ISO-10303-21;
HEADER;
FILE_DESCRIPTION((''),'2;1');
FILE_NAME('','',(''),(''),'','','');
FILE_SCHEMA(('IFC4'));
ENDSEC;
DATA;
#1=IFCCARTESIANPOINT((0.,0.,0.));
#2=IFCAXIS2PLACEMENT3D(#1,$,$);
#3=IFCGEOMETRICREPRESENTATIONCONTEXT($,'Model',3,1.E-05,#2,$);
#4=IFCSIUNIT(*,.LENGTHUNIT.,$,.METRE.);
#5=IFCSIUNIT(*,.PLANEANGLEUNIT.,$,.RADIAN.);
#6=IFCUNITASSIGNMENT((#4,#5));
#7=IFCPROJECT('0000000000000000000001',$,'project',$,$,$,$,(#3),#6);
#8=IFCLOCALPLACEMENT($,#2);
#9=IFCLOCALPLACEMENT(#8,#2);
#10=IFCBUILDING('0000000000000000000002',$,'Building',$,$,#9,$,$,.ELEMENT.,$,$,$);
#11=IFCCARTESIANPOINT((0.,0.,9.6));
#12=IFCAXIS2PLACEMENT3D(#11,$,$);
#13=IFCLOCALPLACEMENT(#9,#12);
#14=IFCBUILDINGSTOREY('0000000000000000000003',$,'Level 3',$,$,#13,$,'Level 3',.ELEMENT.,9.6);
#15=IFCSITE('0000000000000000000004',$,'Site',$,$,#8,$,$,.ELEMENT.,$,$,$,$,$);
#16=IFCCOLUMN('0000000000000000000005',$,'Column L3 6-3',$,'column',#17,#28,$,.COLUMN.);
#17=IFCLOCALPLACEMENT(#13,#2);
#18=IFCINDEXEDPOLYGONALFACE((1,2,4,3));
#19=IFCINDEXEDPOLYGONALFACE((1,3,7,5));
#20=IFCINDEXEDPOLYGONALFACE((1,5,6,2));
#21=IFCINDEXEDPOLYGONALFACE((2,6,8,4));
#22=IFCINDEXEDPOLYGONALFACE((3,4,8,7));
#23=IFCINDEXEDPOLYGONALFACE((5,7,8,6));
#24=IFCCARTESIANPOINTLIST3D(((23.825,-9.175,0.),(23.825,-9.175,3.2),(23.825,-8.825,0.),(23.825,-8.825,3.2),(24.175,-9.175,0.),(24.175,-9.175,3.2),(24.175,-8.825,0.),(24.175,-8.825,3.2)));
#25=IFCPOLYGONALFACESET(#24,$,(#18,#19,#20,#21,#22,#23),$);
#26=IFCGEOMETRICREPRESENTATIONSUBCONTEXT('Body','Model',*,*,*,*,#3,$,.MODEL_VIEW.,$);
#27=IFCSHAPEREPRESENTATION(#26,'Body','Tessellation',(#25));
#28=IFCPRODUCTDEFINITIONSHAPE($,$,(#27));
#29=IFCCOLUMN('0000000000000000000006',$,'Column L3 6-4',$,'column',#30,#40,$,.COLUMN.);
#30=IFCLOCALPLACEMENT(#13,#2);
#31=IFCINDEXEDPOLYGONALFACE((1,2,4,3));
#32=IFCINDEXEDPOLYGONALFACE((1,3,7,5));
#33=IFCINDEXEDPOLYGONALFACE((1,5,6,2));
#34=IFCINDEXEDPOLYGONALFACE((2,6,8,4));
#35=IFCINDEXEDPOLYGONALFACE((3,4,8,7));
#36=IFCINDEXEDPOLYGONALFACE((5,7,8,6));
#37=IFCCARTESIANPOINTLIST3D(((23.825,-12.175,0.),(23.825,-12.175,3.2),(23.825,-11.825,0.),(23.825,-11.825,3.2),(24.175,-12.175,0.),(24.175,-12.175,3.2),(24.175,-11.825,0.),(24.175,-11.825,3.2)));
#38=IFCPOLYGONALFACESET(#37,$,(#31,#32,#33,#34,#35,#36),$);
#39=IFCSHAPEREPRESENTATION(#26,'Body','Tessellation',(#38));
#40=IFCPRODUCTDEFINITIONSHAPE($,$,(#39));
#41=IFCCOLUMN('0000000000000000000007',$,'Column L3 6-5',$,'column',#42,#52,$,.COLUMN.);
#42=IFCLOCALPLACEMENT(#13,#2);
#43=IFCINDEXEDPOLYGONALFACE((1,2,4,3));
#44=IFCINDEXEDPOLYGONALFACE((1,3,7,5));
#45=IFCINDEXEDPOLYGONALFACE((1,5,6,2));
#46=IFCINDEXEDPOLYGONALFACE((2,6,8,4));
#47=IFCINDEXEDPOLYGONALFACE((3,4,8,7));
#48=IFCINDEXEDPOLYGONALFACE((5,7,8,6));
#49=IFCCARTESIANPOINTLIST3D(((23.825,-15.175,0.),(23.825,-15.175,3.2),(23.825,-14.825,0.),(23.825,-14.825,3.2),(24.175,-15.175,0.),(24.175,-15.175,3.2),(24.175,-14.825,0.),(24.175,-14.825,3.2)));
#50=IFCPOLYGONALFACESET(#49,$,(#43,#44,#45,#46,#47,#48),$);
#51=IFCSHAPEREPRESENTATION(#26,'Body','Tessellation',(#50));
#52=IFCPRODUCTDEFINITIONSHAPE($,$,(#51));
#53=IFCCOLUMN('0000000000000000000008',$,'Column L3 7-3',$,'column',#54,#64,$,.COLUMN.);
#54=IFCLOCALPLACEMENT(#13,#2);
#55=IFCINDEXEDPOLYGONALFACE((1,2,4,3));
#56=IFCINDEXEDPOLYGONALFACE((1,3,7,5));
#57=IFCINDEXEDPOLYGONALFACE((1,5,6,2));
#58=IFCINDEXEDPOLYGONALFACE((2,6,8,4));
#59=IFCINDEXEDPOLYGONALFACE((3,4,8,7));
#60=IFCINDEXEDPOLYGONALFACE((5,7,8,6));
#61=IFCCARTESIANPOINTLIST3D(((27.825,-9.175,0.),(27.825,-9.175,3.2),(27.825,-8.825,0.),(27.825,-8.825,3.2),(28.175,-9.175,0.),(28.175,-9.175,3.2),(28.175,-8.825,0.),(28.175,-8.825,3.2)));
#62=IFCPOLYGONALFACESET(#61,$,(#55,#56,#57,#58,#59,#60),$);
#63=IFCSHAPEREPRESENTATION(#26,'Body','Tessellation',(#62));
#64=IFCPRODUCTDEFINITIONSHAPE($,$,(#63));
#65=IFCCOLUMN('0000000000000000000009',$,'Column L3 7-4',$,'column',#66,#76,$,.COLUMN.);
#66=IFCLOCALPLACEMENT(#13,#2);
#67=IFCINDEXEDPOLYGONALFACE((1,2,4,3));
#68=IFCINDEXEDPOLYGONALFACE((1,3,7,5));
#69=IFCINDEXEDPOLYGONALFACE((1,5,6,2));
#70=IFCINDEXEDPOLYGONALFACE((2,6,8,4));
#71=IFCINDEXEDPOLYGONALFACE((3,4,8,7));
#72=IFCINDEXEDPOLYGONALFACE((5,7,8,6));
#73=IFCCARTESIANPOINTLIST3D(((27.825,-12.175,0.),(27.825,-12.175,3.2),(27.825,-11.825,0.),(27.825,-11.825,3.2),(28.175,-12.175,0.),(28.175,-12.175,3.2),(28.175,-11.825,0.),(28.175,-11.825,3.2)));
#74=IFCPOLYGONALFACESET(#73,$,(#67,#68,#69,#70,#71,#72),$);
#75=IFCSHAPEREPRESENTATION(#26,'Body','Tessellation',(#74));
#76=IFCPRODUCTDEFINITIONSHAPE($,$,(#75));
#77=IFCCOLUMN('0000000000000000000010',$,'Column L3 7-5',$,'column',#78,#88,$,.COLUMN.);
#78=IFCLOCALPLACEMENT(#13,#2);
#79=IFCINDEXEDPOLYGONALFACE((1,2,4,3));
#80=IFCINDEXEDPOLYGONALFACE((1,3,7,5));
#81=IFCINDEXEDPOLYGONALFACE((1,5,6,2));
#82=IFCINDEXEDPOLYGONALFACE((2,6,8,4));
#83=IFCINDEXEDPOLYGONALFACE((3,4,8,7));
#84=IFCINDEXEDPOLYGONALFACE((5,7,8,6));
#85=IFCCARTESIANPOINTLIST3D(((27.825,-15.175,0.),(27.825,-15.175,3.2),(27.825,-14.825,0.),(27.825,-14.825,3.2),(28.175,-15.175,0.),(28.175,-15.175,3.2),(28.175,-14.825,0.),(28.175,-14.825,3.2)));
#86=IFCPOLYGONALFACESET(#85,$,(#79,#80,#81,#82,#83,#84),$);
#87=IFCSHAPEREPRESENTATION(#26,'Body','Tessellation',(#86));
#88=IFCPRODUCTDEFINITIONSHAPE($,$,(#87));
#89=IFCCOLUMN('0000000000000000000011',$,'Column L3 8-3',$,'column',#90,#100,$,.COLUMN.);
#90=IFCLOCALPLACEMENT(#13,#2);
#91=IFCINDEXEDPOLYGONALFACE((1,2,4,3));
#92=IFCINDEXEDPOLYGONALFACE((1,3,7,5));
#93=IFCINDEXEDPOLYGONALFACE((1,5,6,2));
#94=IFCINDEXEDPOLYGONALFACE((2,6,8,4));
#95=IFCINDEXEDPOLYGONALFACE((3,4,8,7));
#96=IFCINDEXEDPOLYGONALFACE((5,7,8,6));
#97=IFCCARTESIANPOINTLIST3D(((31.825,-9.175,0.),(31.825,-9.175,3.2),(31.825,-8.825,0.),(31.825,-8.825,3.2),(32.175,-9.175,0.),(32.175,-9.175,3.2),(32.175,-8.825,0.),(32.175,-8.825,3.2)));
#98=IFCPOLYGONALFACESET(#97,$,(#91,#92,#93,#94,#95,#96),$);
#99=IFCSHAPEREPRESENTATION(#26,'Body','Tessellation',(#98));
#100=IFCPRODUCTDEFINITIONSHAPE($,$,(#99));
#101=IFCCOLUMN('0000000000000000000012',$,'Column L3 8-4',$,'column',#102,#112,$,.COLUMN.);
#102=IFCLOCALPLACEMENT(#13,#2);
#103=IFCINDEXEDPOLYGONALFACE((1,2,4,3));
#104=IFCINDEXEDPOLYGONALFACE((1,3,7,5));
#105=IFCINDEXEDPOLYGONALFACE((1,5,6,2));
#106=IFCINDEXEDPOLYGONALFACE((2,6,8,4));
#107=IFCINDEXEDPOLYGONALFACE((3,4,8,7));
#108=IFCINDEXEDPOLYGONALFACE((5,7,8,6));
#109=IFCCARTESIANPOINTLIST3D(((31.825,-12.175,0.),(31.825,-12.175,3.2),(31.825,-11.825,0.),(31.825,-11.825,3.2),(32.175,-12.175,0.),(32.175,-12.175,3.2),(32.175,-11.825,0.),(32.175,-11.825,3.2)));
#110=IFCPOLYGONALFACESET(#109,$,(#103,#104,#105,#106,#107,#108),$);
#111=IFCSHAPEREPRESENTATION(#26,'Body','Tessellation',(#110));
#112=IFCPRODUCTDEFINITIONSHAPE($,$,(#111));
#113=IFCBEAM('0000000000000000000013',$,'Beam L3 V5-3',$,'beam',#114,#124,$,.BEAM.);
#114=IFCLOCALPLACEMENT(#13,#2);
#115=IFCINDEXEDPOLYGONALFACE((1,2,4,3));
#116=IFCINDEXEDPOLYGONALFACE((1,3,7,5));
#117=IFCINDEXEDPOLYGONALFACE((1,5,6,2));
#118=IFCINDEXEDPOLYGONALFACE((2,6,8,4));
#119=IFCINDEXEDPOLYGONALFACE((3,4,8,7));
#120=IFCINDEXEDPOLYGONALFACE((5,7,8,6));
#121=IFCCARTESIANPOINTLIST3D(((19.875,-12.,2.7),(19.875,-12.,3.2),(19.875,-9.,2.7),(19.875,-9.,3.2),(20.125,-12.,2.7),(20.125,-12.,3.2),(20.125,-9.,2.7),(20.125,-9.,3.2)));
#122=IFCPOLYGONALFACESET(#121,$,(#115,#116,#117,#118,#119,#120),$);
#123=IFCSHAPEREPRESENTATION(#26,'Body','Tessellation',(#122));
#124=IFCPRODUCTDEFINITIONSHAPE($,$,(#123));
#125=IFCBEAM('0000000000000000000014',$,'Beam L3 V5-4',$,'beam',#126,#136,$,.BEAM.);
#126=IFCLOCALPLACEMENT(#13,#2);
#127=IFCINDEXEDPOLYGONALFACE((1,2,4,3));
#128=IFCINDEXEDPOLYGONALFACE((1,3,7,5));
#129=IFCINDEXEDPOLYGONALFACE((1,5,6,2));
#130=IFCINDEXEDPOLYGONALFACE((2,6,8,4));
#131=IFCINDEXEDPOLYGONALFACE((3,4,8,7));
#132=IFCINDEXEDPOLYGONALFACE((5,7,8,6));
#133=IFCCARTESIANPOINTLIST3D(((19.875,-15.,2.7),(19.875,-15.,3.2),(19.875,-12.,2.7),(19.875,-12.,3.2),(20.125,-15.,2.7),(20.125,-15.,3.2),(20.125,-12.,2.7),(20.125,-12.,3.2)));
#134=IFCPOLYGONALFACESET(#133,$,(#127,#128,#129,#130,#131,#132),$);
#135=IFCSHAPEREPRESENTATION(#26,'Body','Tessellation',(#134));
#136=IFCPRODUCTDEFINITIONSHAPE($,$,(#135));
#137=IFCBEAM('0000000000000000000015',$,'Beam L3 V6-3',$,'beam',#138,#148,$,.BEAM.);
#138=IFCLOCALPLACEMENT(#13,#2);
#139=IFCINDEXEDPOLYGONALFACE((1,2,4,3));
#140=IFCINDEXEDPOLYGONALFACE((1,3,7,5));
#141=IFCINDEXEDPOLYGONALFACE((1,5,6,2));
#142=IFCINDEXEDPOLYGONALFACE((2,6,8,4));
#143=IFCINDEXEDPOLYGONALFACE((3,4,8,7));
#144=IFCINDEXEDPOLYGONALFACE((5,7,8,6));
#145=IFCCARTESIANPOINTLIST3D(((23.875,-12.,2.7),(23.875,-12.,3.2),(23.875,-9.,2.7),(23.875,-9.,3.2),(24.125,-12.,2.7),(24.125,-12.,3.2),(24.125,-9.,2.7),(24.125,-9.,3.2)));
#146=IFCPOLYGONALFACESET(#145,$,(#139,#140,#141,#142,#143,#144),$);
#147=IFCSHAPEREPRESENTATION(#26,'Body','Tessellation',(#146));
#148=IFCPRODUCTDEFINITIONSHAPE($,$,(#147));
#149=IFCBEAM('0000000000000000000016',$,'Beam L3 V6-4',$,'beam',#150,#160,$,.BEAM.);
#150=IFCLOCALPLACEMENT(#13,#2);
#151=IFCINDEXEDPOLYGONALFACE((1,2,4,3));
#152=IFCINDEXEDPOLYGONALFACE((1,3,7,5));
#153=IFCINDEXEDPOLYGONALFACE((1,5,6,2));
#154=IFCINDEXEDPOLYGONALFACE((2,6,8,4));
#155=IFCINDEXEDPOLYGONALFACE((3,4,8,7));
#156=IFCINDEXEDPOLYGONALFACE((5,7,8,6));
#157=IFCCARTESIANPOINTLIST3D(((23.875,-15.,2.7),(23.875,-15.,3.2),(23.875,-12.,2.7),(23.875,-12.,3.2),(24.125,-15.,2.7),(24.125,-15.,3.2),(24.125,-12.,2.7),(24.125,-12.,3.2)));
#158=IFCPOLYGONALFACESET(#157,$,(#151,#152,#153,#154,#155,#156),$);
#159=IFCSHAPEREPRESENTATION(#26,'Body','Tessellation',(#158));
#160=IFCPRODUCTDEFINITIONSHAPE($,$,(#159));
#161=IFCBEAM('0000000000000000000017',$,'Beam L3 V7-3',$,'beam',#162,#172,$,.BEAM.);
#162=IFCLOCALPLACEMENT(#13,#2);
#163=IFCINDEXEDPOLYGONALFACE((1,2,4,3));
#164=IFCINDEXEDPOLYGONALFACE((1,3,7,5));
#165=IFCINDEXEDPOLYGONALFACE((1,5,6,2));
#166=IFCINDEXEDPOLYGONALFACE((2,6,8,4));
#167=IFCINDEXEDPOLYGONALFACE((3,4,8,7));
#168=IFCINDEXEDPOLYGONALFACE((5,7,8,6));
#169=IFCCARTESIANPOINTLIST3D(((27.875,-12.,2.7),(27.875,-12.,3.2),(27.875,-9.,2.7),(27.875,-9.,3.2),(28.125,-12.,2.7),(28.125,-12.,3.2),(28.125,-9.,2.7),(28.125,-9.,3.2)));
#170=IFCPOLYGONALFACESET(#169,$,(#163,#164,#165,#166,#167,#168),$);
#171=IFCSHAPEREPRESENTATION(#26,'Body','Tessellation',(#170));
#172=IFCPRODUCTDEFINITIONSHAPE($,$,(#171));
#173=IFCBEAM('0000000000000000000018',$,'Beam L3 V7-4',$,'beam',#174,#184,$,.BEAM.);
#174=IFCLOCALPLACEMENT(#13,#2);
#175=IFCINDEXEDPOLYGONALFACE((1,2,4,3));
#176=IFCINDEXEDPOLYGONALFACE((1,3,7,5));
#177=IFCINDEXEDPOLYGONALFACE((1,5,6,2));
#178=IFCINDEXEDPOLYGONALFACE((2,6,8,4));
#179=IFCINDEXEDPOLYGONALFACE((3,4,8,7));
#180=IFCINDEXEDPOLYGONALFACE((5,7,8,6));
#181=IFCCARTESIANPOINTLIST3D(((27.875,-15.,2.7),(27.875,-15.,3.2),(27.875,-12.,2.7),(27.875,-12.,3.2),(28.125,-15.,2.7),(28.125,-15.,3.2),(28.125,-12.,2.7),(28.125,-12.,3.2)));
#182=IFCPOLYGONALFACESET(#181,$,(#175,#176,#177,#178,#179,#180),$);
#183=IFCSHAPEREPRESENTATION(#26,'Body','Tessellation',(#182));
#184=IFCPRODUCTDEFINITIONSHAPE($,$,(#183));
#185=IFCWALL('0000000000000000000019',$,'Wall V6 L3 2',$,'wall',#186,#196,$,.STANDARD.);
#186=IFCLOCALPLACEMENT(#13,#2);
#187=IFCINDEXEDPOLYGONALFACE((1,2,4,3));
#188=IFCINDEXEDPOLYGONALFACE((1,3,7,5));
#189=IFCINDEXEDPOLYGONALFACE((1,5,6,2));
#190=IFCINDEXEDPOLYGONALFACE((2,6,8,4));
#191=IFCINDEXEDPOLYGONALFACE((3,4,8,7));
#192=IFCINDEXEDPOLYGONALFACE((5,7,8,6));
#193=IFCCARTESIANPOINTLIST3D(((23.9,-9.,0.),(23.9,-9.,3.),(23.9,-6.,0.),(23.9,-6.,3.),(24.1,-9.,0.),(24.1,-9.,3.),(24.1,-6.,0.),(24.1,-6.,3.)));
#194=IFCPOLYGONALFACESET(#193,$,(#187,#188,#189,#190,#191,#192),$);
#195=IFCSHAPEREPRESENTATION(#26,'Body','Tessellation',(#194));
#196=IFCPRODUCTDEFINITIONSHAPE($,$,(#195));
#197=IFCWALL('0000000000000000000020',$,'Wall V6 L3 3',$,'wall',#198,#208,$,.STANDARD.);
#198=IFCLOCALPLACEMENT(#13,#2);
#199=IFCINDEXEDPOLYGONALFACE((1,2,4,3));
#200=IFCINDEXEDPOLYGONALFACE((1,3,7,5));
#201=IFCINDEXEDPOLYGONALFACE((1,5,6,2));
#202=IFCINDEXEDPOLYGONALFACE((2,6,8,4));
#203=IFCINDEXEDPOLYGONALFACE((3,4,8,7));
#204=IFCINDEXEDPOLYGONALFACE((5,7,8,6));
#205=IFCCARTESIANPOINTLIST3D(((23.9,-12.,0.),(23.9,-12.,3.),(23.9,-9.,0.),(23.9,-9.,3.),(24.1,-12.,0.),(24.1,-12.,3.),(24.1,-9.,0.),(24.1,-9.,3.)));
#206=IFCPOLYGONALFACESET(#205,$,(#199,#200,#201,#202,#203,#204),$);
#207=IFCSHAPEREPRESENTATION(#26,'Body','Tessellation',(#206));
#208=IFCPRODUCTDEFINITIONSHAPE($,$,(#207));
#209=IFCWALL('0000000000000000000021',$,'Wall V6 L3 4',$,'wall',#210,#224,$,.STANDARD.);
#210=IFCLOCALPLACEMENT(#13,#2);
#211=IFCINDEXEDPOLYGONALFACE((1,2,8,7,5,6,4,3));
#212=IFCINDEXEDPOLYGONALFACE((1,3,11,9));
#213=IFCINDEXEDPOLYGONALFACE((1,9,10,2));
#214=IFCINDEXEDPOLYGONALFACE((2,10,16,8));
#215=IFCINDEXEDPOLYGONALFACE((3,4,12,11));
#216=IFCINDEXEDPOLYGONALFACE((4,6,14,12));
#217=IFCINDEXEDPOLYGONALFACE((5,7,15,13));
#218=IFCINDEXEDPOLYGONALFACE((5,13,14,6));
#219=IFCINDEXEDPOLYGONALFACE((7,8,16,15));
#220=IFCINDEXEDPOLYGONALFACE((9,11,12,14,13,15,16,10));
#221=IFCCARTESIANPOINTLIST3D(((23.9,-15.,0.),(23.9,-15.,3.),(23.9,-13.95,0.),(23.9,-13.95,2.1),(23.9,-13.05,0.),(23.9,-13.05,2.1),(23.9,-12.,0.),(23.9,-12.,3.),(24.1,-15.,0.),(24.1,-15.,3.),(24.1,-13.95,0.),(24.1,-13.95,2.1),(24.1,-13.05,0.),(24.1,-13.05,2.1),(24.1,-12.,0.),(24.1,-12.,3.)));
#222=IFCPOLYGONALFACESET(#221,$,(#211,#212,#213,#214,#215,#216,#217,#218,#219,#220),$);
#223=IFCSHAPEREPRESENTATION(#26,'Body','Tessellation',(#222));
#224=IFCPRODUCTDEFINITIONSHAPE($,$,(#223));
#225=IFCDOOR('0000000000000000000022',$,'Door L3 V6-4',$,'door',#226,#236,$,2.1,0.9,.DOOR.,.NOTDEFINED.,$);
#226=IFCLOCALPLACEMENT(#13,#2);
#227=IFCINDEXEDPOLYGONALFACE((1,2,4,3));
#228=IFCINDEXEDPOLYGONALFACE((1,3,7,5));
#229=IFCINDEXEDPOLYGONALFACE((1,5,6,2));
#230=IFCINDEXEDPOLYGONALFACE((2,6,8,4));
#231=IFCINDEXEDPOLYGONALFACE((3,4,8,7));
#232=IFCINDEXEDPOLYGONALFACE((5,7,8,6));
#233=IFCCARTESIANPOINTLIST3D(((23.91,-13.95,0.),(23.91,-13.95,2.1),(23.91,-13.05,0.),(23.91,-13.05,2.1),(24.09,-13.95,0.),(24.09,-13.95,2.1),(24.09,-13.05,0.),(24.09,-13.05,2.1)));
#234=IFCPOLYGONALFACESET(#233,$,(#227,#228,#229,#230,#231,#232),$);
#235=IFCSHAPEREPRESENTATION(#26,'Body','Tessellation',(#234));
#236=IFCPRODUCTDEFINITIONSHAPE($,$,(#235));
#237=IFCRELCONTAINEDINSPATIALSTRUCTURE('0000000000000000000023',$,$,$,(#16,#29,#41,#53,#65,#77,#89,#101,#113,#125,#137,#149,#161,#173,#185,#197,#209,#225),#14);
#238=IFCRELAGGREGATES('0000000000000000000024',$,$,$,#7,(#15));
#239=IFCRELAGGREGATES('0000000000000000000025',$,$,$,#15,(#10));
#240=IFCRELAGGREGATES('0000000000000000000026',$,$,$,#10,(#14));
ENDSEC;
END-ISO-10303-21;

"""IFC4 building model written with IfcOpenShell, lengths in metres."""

from ifc_helpers import new_model, si_unit, frame, frame_2d, origin, origin_2d, place, context, subcontext, project, spatial, rectangle, extrude, element, fill, save


model = new_model("IFC4")

# Units and contexts
model_context = context("Model", 3, precision=1e-05, world=origin())
body_context = subcontext(model_context, "Body", "Model", "MODEL_VIEW")
ifc_project = project(units=[si_unit("LENGTHUNIT", "METRE"), si_unit("PLANEANGLEUNIT", "RADIAN")], contexts=[model_context])

# Site, building, storey
site_placement = place(None, origin())
site = spatial("IfcSite", under=ifc_project, at=site_placement, Name="Site", CompositionType="ELEMENT")
building_placement = place(site_placement, origin())
building = spatial("IfcBuilding", under=site, at=building_placement, Name="Building", CompositionType="ELEMENT")
storey_placement = place(building_placement, frame((0.0, 0.0, 9.6)))
storey = spatial("IfcBuildingStorey", under=building, at=storey_placement, Name="Level 3", LongName="Level 3", CompositionType="ELEMENT", Elevation=9.6)

# Columns
for number, where, name in (
    (1, (24.0, -9.0, 0.0), "Column L3 6-3"),
    (2, (24.0, -12.0, 0.0), "Column L3 6-4"),
    (3, (24.0, -15.0, 0.0), "Column L3 6-5"),
    (4, (28.0, -9.0, 0.0), "Column L3 7-3"),
    (5, (28.0, -12.0, 0.0), "Column L3 7-4"),
    (6, (28.0, -15.0, 0.0), "Column L3 7-5"),
    (7, (32.0, -9.0, 0.0), "Column L3 8-3"),
    (8, (32.0, -12.0, 0.0), "Column L3 8-4"),
):
    element("IfcColumn", number, at=place(storey_placement, frame(where)), inside=storey, Name=name, ObjectType="column", PredefinedType="COLUMN", context=body_context, shape_type="SweptSolid", body=[
        extrude(rectangle(XDim=0.35, YDim=0.35, at=origin_2d()), origin(), (0.0, 0.0, 1.0), 3.2),
    ])

# Beams
for number, where, z_axis, x_axis, name in (
    (9, (20.0, -9.0, 2.95), (0.0, -1.0, 0.0), (0.0, 0.0, 1.0), "Beam L3 V5-3"),
    (10, (20.0, -12.0, 2.95), (0.0, -1.0, 0.0), (0.0, 0.0, 1.0), "Beam L3 V5-4"),
    (11, (24.0, -9.0, 2.95), (0.0, -1.0, 0.0), (0.0, 0.0, 1.0), "Beam L3 V6-3"),
    (12, (24.0, -12.0, 2.95), (0.0, -1.0, 0.0), (0.0, 0.0, 1.0), "Beam L3 V6-4"),
    (13, (28.0, -9.0, 2.95), (0.0, -1.0, 0.0), (0.0, 0.0, 1.0), "Beam L3 V7-3"),
    (14, (28.0, -12.0, 2.95), (0.0, -1.0, 0.0), (0.0, 0.0, 1.0), "Beam L3 V7-4"),
):
    element("IfcBeam", number, at=place(storey_placement, frame(where, z_axis=z_axis, x_axis=x_axis)), inside=storey, Name=name, ObjectType="beam", PredefinedType="BEAM", context=body_context, shape_type="SweptSolid", body=[
        extrude(rectangle(XDim=0.5, YDim=0.25, at=origin_2d()), origin(), (0.0, 0.0, 1.0), 3.0),
    ])

# Walls
for number, where, z_axis, x_axis, name in (
    (15, (24.0, -6.0, 0.0), (0.0, 0.0, 1.0), (0.0, -1.0, 0.0), "Wall V6 L3 2"),
    (16, (24.0, -9.0, 0.0), (0.0, 0.0, 1.0), (0.0, -1.0, 0.0), "Wall V6 L3 3"),
):
    element("IfcWall", number, at=place(storey_placement, frame(where, z_axis=z_axis, x_axis=x_axis)), inside=storey, Name=name, ObjectType="wall", PredefinedType="STANDARD", context=body_context, shape_type="SweptSolid", body=[
        extrude(rectangle(XDim=3.0, YDim=0.2, at=frame_2d((1.5, 0.0))), origin(), (0.0, 0.0, 1.0), 3.0),
    ])

# Wall, opening, door
wall_1_placement = place(storey_placement, frame((24.0, -12.0, 0.0), z_axis=(0.0, 0.0, 1.0), x_axis=(0.0, -1.0, 0.0)))
wall_1 = element("IfcWall", 17, at=wall_1_placement, inside=storey, Name="Wall V6 L3 4", ObjectType="wall", PredefinedType="STANDARD", context=body_context, shape_type="SweptSolid", body=[
    extrude(rectangle(XDim=3.0, YDim=0.2, at=frame_2d((1.5, 0.0))), origin(), (0.0, 0.0, 1.0), 3.0),
])
opening_1_placement = place(storey_placement, frame((24.0, -13.5, 0.0), z_axis=(0.0, 0.0, 1.0), x_axis=(0.0, -1.0, 0.0)))
opening_1 = element("IfcOpeningElement", 18, at=opening_1_placement, cuts=wall_1, ObjectType="Opening", PredefinedType="OPENING", context=body_context, shape_type="SweptSolid", body=[
    extrude(rectangle(XDim=0.9, YDim=0.22, at=origin_2d()), origin(), (0.0, 0.0, 1.0), 2.1),
])
door_1_placement = place(storey_placement, frame((24.0, -13.5, 0.0), z_axis=(0.0, 0.0, 1.0), x_axis=(0.0, -1.0, 0.0)))
door_1 = element("IfcDoor", 19, at=door_1_placement, inside=storey, Name="Door L3 V6-4", ObjectType="door", OperationType="NOTDEFINED", OverallHeight=2.1, OverallWidth=0.9, PredefinedType="DOOR", context=body_context, shape_type="SweptSolid", body=[
    extrude(rectangle(XDim=0.9, YDim=0.18, at=origin_2d()), origin(), (0.0, 0.0, 1.0), 2.1),
])
fill(opening_1, door_1)

save(model, "model.ifc")
